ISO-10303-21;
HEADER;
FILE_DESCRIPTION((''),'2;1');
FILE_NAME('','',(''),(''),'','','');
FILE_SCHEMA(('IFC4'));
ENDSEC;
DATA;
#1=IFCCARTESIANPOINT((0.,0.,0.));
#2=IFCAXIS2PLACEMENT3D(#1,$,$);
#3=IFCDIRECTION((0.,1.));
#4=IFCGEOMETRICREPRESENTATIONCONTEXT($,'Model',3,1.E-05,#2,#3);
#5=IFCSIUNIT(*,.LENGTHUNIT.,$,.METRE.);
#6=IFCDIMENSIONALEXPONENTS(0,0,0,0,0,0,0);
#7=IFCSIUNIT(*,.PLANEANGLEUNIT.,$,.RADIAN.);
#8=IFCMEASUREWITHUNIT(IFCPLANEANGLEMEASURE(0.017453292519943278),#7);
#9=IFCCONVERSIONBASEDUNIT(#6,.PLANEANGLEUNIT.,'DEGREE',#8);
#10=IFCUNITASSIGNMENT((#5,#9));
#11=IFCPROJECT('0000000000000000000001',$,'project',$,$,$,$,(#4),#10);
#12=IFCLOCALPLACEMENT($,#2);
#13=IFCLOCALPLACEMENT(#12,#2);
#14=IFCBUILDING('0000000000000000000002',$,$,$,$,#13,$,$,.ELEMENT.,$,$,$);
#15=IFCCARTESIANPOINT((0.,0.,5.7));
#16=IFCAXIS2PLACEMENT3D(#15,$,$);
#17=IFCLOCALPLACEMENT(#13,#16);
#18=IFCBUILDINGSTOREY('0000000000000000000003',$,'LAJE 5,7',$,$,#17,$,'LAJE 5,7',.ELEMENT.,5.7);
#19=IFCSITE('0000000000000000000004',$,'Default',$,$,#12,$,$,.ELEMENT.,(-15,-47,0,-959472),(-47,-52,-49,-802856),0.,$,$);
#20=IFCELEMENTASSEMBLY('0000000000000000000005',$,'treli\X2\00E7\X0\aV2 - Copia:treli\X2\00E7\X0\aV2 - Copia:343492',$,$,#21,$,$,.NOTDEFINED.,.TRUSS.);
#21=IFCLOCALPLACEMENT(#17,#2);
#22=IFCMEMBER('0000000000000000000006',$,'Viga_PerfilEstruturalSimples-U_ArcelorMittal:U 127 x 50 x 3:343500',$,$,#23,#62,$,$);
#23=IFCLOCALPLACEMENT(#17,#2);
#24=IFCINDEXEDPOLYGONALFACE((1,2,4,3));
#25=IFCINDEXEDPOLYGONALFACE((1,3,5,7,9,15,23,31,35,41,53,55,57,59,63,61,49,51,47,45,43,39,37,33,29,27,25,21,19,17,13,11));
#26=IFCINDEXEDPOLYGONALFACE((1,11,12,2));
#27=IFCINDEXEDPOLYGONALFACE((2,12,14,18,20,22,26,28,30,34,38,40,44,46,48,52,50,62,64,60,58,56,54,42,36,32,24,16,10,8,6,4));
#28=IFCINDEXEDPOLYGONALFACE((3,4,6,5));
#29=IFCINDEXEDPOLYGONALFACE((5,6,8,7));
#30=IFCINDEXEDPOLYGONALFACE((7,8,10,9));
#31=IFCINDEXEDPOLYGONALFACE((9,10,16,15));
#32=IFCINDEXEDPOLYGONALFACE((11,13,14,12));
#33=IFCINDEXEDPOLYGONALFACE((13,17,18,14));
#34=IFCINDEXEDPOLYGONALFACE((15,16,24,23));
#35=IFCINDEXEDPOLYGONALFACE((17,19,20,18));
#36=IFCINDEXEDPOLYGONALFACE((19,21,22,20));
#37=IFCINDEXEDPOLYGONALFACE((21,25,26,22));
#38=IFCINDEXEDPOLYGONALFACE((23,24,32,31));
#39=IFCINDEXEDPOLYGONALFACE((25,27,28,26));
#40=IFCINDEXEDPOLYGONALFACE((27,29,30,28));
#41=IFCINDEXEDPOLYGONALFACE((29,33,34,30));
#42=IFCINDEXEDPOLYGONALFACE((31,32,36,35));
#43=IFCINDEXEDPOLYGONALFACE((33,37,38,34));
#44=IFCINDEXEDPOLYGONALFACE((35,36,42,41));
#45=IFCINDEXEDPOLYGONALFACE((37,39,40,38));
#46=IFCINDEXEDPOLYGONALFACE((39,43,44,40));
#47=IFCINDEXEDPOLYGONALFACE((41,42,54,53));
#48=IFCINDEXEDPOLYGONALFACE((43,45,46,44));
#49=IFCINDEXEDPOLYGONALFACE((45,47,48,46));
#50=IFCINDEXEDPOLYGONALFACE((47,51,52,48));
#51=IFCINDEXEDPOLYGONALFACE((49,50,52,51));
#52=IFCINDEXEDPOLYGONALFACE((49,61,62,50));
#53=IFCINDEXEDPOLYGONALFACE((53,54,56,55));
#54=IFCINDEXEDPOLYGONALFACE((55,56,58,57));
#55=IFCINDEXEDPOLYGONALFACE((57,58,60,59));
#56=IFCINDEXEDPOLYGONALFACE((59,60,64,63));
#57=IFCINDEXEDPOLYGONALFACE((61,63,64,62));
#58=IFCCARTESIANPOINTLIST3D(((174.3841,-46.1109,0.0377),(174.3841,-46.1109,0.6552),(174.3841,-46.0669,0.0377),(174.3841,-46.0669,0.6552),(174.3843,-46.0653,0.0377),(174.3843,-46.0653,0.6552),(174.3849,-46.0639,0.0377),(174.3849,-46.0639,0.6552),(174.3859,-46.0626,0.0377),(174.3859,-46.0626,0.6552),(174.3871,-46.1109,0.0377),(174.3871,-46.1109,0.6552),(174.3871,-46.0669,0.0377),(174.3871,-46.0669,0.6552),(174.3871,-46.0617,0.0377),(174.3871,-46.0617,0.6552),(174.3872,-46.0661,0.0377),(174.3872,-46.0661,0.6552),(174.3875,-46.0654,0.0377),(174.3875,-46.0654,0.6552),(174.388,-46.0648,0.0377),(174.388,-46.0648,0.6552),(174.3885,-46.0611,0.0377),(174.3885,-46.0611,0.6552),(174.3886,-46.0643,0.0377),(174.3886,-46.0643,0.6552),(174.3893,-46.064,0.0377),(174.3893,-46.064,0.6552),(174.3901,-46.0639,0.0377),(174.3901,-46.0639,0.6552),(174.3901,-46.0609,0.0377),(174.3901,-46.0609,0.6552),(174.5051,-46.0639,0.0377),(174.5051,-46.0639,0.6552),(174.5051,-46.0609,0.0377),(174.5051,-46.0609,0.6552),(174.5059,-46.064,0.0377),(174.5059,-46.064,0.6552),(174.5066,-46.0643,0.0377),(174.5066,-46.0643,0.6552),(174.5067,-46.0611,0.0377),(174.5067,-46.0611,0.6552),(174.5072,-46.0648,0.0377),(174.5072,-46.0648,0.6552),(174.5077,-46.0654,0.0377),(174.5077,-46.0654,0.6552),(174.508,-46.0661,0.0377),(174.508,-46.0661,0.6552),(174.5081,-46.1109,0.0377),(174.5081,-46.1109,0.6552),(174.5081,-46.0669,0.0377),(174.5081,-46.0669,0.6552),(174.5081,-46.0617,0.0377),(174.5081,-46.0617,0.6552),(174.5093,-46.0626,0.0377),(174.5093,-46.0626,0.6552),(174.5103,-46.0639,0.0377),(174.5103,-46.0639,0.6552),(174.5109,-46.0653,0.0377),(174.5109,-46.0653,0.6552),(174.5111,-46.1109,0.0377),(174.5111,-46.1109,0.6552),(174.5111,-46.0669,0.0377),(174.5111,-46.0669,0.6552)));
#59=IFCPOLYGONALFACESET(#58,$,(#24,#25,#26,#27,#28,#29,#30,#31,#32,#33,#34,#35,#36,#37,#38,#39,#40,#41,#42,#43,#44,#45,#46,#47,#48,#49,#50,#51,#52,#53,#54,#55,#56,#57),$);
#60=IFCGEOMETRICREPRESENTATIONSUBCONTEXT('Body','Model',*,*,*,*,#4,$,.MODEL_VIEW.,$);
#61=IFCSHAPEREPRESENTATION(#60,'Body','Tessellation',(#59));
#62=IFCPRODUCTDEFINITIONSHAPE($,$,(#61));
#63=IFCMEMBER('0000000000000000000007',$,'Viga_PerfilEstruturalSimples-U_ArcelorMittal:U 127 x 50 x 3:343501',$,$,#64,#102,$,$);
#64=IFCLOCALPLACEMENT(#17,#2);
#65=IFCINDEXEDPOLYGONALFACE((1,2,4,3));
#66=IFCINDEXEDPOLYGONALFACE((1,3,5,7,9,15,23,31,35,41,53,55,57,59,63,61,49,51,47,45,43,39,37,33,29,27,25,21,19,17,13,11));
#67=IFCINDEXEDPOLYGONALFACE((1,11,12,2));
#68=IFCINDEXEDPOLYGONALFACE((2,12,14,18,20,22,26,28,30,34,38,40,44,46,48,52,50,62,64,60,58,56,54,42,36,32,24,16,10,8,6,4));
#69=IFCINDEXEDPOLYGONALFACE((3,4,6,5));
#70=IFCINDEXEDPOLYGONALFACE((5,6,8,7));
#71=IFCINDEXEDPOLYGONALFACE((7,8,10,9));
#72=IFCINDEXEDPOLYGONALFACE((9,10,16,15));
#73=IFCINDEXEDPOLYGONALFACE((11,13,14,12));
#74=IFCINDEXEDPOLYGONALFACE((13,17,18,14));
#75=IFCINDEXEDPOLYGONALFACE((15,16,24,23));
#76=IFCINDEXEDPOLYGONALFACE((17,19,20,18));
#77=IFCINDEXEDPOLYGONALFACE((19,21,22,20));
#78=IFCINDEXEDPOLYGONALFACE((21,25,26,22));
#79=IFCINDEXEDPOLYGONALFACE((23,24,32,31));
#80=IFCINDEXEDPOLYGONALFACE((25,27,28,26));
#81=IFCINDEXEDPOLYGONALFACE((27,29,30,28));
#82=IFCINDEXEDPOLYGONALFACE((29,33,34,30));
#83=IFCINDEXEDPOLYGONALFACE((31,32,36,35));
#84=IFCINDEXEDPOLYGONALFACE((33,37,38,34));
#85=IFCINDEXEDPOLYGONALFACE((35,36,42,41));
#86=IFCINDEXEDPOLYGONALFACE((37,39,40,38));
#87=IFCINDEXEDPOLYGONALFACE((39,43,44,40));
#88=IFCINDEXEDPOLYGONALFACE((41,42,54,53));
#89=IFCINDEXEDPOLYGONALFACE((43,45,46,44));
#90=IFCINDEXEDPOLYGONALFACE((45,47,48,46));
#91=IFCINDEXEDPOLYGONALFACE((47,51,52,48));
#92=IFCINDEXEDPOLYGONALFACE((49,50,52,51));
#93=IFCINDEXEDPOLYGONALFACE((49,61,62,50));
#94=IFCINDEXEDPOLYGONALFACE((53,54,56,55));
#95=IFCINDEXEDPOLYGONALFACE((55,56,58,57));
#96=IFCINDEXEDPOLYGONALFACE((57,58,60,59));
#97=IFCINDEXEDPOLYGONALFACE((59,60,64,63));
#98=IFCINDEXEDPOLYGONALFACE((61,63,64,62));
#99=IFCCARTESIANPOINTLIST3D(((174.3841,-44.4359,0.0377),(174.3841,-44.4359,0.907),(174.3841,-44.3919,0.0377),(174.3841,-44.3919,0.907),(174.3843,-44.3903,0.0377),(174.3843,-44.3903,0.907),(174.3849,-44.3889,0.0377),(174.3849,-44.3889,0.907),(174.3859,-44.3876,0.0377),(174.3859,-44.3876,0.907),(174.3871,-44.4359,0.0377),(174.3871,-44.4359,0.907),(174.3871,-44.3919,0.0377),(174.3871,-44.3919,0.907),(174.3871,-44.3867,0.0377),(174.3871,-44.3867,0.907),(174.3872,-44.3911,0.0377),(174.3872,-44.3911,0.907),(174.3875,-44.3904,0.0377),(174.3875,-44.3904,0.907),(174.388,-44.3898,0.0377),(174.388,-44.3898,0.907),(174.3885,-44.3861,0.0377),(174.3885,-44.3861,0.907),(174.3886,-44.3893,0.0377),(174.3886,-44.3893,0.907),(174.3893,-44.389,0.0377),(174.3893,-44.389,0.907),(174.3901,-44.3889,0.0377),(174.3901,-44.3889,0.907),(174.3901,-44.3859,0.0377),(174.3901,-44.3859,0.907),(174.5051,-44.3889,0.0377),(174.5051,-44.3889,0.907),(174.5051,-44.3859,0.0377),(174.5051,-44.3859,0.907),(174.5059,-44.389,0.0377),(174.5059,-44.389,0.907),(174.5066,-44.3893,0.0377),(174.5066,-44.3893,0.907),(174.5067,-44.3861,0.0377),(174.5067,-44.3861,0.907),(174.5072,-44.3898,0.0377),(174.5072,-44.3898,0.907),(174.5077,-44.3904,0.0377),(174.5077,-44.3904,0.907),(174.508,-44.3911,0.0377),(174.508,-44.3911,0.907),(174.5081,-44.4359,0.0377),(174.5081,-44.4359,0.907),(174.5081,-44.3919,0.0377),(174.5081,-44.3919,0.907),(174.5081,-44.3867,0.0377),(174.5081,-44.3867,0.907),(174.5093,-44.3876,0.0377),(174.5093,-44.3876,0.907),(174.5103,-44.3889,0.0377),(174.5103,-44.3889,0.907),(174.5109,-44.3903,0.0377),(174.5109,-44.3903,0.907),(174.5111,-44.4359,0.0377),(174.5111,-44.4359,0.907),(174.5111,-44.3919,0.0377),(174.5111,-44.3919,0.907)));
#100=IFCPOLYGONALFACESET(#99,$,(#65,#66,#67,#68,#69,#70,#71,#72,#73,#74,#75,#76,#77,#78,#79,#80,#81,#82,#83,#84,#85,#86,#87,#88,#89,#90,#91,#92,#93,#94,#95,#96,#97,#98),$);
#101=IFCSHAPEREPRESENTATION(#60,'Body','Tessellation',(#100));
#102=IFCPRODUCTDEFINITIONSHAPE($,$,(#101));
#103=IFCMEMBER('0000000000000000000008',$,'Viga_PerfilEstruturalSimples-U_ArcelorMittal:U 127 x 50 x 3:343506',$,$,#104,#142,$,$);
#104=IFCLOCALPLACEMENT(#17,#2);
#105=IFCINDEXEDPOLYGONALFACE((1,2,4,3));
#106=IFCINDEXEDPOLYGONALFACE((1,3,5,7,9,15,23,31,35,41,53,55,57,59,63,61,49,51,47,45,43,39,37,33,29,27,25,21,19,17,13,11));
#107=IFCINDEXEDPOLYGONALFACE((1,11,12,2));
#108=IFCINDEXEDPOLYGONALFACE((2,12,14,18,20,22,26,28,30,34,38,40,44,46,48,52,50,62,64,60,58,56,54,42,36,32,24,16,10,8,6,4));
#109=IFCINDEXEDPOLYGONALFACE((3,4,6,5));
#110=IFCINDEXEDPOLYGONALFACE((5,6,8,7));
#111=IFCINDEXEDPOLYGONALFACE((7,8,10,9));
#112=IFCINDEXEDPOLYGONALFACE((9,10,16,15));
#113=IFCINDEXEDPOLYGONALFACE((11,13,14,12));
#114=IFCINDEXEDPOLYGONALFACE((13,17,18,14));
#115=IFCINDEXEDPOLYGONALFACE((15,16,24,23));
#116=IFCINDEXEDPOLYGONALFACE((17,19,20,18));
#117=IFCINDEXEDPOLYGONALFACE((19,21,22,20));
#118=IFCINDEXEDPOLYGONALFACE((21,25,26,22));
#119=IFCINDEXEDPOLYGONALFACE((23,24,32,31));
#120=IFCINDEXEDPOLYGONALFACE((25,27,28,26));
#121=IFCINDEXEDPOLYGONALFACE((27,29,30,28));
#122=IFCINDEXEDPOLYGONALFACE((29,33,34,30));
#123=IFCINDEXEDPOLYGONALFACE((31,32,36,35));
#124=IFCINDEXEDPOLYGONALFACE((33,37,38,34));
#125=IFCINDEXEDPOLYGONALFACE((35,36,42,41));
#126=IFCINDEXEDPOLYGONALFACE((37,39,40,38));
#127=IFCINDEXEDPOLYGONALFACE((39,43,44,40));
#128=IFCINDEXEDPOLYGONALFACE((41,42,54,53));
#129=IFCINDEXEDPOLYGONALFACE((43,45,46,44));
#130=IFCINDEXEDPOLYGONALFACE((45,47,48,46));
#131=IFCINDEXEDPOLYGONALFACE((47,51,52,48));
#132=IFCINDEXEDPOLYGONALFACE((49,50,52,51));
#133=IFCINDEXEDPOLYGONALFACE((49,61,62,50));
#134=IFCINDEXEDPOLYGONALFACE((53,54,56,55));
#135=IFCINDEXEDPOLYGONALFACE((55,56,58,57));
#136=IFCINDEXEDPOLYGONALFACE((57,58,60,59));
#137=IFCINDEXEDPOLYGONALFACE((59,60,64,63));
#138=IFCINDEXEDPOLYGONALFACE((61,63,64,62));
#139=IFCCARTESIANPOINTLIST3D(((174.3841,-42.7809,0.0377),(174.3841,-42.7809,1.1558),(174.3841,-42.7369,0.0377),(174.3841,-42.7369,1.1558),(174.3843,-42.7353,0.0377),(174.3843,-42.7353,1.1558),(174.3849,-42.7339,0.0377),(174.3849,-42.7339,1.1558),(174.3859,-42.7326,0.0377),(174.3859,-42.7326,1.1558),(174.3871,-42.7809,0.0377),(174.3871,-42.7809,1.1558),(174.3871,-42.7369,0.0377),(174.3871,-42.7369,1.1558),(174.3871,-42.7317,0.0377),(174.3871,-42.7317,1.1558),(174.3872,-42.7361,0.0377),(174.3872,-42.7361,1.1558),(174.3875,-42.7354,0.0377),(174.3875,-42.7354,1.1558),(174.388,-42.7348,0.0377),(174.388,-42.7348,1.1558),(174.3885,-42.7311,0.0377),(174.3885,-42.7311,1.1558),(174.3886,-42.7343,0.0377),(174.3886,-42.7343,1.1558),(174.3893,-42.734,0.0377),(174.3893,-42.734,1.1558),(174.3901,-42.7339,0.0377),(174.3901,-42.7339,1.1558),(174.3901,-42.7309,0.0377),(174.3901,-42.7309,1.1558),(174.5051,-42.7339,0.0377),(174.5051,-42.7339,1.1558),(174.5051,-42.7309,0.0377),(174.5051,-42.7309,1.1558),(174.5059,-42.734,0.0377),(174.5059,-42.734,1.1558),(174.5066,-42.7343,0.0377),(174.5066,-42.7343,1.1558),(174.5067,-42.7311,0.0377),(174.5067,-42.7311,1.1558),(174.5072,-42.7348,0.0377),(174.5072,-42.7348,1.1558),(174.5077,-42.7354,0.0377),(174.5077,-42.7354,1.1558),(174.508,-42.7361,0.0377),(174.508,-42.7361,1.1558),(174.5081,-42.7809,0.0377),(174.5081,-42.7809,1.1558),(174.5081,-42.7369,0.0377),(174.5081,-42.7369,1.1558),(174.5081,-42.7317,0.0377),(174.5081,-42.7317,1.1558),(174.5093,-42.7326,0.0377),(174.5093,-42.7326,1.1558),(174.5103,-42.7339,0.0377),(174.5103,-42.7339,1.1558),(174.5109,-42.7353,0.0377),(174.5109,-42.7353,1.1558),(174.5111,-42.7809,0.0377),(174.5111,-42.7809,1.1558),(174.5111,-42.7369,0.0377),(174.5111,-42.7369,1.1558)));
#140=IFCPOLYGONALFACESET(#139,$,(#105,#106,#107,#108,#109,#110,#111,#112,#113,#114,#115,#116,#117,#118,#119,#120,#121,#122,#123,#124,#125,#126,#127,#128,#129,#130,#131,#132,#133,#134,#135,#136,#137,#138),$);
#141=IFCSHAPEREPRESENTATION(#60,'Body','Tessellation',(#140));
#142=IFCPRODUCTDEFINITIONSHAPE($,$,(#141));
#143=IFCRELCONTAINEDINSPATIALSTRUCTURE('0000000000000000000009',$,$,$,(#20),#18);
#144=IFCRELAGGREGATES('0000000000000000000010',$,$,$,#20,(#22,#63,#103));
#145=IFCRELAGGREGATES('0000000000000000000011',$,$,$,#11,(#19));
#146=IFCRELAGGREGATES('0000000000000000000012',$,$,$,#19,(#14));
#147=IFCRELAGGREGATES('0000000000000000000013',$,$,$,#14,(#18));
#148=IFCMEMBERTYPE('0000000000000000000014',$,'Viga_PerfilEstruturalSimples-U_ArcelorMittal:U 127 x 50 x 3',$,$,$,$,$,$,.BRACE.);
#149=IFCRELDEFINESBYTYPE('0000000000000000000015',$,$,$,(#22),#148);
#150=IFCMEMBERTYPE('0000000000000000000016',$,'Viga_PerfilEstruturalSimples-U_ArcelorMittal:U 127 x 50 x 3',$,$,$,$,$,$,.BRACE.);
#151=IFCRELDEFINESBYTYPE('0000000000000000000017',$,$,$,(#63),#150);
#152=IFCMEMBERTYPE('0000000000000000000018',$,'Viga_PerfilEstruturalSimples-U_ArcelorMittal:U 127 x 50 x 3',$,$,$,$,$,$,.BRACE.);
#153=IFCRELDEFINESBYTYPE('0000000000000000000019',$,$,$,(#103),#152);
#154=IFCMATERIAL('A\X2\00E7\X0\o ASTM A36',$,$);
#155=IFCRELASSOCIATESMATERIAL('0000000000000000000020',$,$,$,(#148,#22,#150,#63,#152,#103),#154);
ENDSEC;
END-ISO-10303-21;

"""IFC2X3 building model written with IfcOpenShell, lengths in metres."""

from ifc_helpers import new_model, entity, si_unit, converted_unit, direction, frame, frame_2d, origin, place, context, subcontext, project, spatial, polyline, circle_curve, parameter, trimmed, segment, composite_curve, outline, extrude, source, transform, mapped, material, type_object, type_shapes, element, aggregate, save


model = new_model("IFC2X3")

# Units and contexts
model_context = context("Model", 3, precision=1e-05, world=origin(), true_north=direction((0.0, 1.0)))
body_context = subcontext(model_context, "Body", "Model", "MODEL_VIEW")
ifc_project = project(units=[si_unit("LENGTHUNIT", "METRE"), converted_unit("PLANEANGLEUNIT", "DEGREE", entity("IfcPlaneAngleMeasure", 0.017453292519943278), si_unit("PLANEANGLEUNIT", "RADIAN"), dimensions=[0, 0, 0, 0, 0, 0, 0])], contexts=[model_context])

# Site, building, storey
site_placement = place(None, origin())
site = spatial("IfcSite", under=ifc_project, at=site_placement, Name="Default", CompositionType="ELEMENT", RefLatitude=(-15, -47, 0, -959472), RefLongitude=(-47, -52, -49, -802856), RefElevation=0.0)
building_placement = place(site_placement, origin())
building = spatial("IfcBuilding", under=site, at=building_placement, CompositionType="ELEMENT")
storey_placement = place(building_placement, frame((0.0, 0.0, 5.7)))
storey = spatial("IfcBuildingStorey", under=building, at=storey_placement, Name="LAJE 5,7", LongName="LAJE 5,7", CompositionType="ELEMENT", Elevation=5.7)

# Element assembly, members
assembly_1_placement = place(storey_placement, origin())
assembly_1 = element("IfcElementAssembly", 1, at=assembly_1_placement, inside=storey, Name="treliçaV2 - Copia:treliçaV2 - Copia:343492", AssemblyPlace="NOTDEFINED", PredefinedType="TRUSS")
ifc_material = material(Name="Aço ASTM A36")
member_type_1 = type_object("IfcMemberType", Name="Viga_PerfilEstruturalSimples-U_ArcelorMittal:U 127 x 50 x 3", PredefinedType="BRACE", material=ifc_material)
shared_shape_1 = source(origin(), body_context, "Body", "SweptSolid", [
    extrude(outline(composite_curve([segment(polyline([(-0.0575, -0.0192), (0.0575, -0.0192)]), True, "CONTINUOUS"), segment(trimmed(circle_curve(frame_2d((0.0575, -0.0132), x_axis=(0.0, 1.0)), 0.006), [parameter(180.0)], [parameter(270.0)], True, "PARAMETER"), True, "CONTINUOUS"), segment(polyline([(0.0635, -0.0132), (0.0635, 0.0308)]), True, "CONTINUOUS"), segment(polyline([(0.0635, 0.0308), (0.0605, 0.0308)]), True, "CONTINUOUS"), segment(polyline([(0.0605, 0.0308), (0.0605, -0.0132)]), True, "CONTINUOUS"), segment(trimmed(circle_curve(frame_2d((0.0575, -0.0132), x_axis=(0.0, 1.0)), 0.003), [parameter(180.0)], [parameter(270.0)], True, "PARAMETER"), False, "CONTINUOUS"), segment(polyline([(0.0575, -0.0162), (-0.0575, -0.0162)]), True, "CONTINUOUS"), segment(trimmed(circle_curve(frame_2d((-0.0575, -0.0132), x_axis=(0.0, 1.0)), 0.003), [parameter(90.0)], [parameter(180.0)], True, "PARAMETER"), False, "CONTINUOUS"), segment(polyline([(-0.0605, -0.0132), (-0.0605, 0.0308)]), True, "CONTINUOUS"), segment(polyline([(-0.0605, 0.0308), (-0.0635, 0.0308)]), True, "CONTINUOUS"), segment(polyline([(-0.0635, 0.0308), (-0.0635, -0.0132)]), True, "CONTINUOUS"), segment(trimmed(circle_curve(frame_2d((-0.0575, -0.0132), x_axis=(0.0, 1.0)), 0.006), [parameter(90.0)], [parameter(180.0)], True, "PARAMETER"), True, "CONTINUOUS")], self_intersect=False)), frame((-0.3108, -0.0058, 0.0), z_axis=(1.0, 0.0, 0.0), x_axis=(0.0, 0.0, -1.0)), (0.0, 0.0, 1.0), 0.6175),
])
type_shapes(member_type_1, [shared_shape_1])
member_1_placement = place(assembly_1_placement, frame((174.4476, -46.0859, 0.3485), z_axis=(1.0, 0.0, 0.0), x_axis=(0.0, 0.0, 1.0)))
member_1 = element("IfcMember", 2, at=member_1_placement, type_object=member_type_1, material=ifc_material, Name="Viga_PerfilEstruturalSimples-U_ArcelorMittal:U 127 x 50 x 3:343500", context=body_context, shape_type="MappedRepresentation", body=[
    mapped(shared_shape_1, transform((0.0, 0.0, 0.0), scale=1.0)),
])
member_type_2 = type_object("IfcMemberType", Name="Viga_PerfilEstruturalSimples-U_ArcelorMittal:U 127 x 50 x 3", PredefinedType="BRACE", material=ifc_material)
shared_shape_2 = source(origin(), body_context, "Body", "SweptSolid", [
    extrude(outline(composite_curve([segment(polyline([(-0.0575, -0.0192), (0.0575, -0.0192)]), True, "CONTINUOUS"), segment(trimmed(circle_curve(frame_2d((0.0575, -0.0132), x_axis=(0.0, 1.0)), 0.006), [parameter(180.0)], [parameter(270.0)], True, "PARAMETER"), True, "CONTINUOUS"), segment(polyline([(0.0635, -0.0132), (0.0635, 0.0308)]), True, "CONTINUOUS"), segment(polyline([(0.0635, 0.0308), (0.0605, 0.0308)]), True, "CONTINUOUS"), segment(polyline([(0.0605, 0.0308), (0.0605, -0.0132)]), True, "CONTINUOUS"), segment(trimmed(circle_curve(frame_2d((0.0575, -0.0132), x_axis=(0.0, 1.0)), 0.003), [parameter(180.0)], [parameter(270.0)], True, "PARAMETER"), False, "CONTINUOUS"), segment(polyline([(0.0575, -0.0162), (-0.0575, -0.0162)]), True, "CONTINUOUS"), segment(trimmed(circle_curve(frame_2d((-0.0575, -0.0132), x_axis=(0.0, 1.0)), 0.003), [parameter(90.0)], [parameter(180.0)], True, "PARAMETER"), False, "CONTINUOUS"), segment(polyline([(-0.0605, -0.0132), (-0.0605, 0.0308)]), True, "CONTINUOUS"), segment(polyline([(-0.0605, 0.0308), (-0.0635, 0.0308)]), True, "CONTINUOUS"), segment(polyline([(-0.0635, 0.0308), (-0.0635, -0.0132)]), True, "CONTINUOUS"), segment(trimmed(circle_curve(frame_2d((-0.0575, -0.0132), x_axis=(0.0, 1.0)), 0.006), [parameter(90.0)], [parameter(180.0)], True, "PARAMETER"), True, "CONTINUOUS")], self_intersect=False)), frame((-0.4367, -0.0058, 0.0), z_axis=(1.0, 0.0, 0.0), x_axis=(0.0, 0.0, -1.0)), (0.0, 0.0, 1.0), 0.8693),
])
type_shapes(member_type_2, [shared_shape_2])
member_2_placement = place(assembly_1_placement, frame((174.4476, -44.4109, 0.4744), z_axis=(1.0, 0.0, 0.0), x_axis=(0.0, 0.0, 1.0)))
member_2 = element("IfcMember", 3, at=member_2_placement, type_object=member_type_2, material=ifc_material, Name="Viga_PerfilEstruturalSimples-U_ArcelorMittal:U 127 x 50 x 3:343501", context=body_context, shape_type="MappedRepresentation", body=[
    mapped(shared_shape_2, transform((0.0, 0.0, 0.0), scale=1.0)),
])
member_type_3 = type_object("IfcMemberType", Name="Viga_PerfilEstruturalSimples-U_ArcelorMittal:U 127 x 50 x 3", PredefinedType="BRACE", material=ifc_material)
shared_shape_3 = source(origin(), body_context, "Body", "SweptSolid", [
    extrude(outline(composite_curve([segment(polyline([(-0.0575, -0.0192), (0.0575, -0.0192)]), True, "CONTINUOUS"), segment(trimmed(circle_curve(frame_2d((0.0575, -0.0132), x_axis=(0.0, 1.0)), 0.006), [parameter(180.0)], [parameter(270.0)], True, "PARAMETER"), True, "CONTINUOUS"), segment(polyline([(0.0635, -0.0132), (0.0635, 0.0308)]), True, "CONTINUOUS"), segment(polyline([(0.0635, 0.0308), (0.0605, 0.0308)]), True, "CONTINUOUS"), segment(polyline([(0.0605, 0.0308), (0.0605, -0.0132)]), True, "CONTINUOUS"), segment(trimmed(circle_curve(frame_2d((0.0575, -0.0132), x_axis=(0.0, 1.0)), 0.003), [parameter(180.0)], [parameter(270.0)], True, "PARAMETER"), False, "CONTINUOUS"), segment(polyline([(0.0575, -0.0162), (-0.0575, -0.0162)]), True, "CONTINUOUS"), segment(trimmed(circle_curve(frame_2d((-0.0575, -0.0132), x_axis=(0.0, 1.0)), 0.003), [parameter(90.0)], [parameter(180.0)], True, "PARAMETER"), False, "CONTINUOUS"), segment(polyline([(-0.0605, -0.0132), (-0.0605, 0.0308)]), True, "CONTINUOUS"), segment(polyline([(-0.0605, 0.0308), (-0.0635, 0.0308)]), True, "CONTINUOUS"), segment(polyline([(-0.0635, 0.0308), (-0.0635, -0.0132)]), True, "CONTINUOUS"), segment(trimmed(circle_curve(frame_2d((-0.0575, -0.0132), x_axis=(0.0, 1.0)), 0.006), [parameter(90.0)], [parameter(180.0)], True, "PARAMETER"), True, "CONTINUOUS")], self_intersect=False)), frame((-0.5611, -0.0058, 0.0), z_axis=(1.0, 0.0, 0.0), x_axis=(0.0, 0.0, -1.0)), (0.0, 0.0, 1.0), 1.1181),
])
type_shapes(member_type_3, [shared_shape_3])
member_3_placement = place(assembly_1_placement, frame((174.4476, -42.7559, 0.5988), z_axis=(1.0, 0.0, 0.0), x_axis=(0.0, 0.0, 1.0)))
member_3 = element("IfcMember", 4, at=member_3_placement, type_object=member_type_3, material=ifc_material, Name="Viga_PerfilEstruturalSimples-U_ArcelorMittal:U 127 x 50 x 3:343506", context=body_context, shape_type="MappedRepresentation", body=[
    mapped(shared_shape_3, transform((0.0, 0.0, 0.0), scale=1.0)),
])

aggregate(assembly_1, [member_1, member_2, member_3])

save(model, "model.ifc")
